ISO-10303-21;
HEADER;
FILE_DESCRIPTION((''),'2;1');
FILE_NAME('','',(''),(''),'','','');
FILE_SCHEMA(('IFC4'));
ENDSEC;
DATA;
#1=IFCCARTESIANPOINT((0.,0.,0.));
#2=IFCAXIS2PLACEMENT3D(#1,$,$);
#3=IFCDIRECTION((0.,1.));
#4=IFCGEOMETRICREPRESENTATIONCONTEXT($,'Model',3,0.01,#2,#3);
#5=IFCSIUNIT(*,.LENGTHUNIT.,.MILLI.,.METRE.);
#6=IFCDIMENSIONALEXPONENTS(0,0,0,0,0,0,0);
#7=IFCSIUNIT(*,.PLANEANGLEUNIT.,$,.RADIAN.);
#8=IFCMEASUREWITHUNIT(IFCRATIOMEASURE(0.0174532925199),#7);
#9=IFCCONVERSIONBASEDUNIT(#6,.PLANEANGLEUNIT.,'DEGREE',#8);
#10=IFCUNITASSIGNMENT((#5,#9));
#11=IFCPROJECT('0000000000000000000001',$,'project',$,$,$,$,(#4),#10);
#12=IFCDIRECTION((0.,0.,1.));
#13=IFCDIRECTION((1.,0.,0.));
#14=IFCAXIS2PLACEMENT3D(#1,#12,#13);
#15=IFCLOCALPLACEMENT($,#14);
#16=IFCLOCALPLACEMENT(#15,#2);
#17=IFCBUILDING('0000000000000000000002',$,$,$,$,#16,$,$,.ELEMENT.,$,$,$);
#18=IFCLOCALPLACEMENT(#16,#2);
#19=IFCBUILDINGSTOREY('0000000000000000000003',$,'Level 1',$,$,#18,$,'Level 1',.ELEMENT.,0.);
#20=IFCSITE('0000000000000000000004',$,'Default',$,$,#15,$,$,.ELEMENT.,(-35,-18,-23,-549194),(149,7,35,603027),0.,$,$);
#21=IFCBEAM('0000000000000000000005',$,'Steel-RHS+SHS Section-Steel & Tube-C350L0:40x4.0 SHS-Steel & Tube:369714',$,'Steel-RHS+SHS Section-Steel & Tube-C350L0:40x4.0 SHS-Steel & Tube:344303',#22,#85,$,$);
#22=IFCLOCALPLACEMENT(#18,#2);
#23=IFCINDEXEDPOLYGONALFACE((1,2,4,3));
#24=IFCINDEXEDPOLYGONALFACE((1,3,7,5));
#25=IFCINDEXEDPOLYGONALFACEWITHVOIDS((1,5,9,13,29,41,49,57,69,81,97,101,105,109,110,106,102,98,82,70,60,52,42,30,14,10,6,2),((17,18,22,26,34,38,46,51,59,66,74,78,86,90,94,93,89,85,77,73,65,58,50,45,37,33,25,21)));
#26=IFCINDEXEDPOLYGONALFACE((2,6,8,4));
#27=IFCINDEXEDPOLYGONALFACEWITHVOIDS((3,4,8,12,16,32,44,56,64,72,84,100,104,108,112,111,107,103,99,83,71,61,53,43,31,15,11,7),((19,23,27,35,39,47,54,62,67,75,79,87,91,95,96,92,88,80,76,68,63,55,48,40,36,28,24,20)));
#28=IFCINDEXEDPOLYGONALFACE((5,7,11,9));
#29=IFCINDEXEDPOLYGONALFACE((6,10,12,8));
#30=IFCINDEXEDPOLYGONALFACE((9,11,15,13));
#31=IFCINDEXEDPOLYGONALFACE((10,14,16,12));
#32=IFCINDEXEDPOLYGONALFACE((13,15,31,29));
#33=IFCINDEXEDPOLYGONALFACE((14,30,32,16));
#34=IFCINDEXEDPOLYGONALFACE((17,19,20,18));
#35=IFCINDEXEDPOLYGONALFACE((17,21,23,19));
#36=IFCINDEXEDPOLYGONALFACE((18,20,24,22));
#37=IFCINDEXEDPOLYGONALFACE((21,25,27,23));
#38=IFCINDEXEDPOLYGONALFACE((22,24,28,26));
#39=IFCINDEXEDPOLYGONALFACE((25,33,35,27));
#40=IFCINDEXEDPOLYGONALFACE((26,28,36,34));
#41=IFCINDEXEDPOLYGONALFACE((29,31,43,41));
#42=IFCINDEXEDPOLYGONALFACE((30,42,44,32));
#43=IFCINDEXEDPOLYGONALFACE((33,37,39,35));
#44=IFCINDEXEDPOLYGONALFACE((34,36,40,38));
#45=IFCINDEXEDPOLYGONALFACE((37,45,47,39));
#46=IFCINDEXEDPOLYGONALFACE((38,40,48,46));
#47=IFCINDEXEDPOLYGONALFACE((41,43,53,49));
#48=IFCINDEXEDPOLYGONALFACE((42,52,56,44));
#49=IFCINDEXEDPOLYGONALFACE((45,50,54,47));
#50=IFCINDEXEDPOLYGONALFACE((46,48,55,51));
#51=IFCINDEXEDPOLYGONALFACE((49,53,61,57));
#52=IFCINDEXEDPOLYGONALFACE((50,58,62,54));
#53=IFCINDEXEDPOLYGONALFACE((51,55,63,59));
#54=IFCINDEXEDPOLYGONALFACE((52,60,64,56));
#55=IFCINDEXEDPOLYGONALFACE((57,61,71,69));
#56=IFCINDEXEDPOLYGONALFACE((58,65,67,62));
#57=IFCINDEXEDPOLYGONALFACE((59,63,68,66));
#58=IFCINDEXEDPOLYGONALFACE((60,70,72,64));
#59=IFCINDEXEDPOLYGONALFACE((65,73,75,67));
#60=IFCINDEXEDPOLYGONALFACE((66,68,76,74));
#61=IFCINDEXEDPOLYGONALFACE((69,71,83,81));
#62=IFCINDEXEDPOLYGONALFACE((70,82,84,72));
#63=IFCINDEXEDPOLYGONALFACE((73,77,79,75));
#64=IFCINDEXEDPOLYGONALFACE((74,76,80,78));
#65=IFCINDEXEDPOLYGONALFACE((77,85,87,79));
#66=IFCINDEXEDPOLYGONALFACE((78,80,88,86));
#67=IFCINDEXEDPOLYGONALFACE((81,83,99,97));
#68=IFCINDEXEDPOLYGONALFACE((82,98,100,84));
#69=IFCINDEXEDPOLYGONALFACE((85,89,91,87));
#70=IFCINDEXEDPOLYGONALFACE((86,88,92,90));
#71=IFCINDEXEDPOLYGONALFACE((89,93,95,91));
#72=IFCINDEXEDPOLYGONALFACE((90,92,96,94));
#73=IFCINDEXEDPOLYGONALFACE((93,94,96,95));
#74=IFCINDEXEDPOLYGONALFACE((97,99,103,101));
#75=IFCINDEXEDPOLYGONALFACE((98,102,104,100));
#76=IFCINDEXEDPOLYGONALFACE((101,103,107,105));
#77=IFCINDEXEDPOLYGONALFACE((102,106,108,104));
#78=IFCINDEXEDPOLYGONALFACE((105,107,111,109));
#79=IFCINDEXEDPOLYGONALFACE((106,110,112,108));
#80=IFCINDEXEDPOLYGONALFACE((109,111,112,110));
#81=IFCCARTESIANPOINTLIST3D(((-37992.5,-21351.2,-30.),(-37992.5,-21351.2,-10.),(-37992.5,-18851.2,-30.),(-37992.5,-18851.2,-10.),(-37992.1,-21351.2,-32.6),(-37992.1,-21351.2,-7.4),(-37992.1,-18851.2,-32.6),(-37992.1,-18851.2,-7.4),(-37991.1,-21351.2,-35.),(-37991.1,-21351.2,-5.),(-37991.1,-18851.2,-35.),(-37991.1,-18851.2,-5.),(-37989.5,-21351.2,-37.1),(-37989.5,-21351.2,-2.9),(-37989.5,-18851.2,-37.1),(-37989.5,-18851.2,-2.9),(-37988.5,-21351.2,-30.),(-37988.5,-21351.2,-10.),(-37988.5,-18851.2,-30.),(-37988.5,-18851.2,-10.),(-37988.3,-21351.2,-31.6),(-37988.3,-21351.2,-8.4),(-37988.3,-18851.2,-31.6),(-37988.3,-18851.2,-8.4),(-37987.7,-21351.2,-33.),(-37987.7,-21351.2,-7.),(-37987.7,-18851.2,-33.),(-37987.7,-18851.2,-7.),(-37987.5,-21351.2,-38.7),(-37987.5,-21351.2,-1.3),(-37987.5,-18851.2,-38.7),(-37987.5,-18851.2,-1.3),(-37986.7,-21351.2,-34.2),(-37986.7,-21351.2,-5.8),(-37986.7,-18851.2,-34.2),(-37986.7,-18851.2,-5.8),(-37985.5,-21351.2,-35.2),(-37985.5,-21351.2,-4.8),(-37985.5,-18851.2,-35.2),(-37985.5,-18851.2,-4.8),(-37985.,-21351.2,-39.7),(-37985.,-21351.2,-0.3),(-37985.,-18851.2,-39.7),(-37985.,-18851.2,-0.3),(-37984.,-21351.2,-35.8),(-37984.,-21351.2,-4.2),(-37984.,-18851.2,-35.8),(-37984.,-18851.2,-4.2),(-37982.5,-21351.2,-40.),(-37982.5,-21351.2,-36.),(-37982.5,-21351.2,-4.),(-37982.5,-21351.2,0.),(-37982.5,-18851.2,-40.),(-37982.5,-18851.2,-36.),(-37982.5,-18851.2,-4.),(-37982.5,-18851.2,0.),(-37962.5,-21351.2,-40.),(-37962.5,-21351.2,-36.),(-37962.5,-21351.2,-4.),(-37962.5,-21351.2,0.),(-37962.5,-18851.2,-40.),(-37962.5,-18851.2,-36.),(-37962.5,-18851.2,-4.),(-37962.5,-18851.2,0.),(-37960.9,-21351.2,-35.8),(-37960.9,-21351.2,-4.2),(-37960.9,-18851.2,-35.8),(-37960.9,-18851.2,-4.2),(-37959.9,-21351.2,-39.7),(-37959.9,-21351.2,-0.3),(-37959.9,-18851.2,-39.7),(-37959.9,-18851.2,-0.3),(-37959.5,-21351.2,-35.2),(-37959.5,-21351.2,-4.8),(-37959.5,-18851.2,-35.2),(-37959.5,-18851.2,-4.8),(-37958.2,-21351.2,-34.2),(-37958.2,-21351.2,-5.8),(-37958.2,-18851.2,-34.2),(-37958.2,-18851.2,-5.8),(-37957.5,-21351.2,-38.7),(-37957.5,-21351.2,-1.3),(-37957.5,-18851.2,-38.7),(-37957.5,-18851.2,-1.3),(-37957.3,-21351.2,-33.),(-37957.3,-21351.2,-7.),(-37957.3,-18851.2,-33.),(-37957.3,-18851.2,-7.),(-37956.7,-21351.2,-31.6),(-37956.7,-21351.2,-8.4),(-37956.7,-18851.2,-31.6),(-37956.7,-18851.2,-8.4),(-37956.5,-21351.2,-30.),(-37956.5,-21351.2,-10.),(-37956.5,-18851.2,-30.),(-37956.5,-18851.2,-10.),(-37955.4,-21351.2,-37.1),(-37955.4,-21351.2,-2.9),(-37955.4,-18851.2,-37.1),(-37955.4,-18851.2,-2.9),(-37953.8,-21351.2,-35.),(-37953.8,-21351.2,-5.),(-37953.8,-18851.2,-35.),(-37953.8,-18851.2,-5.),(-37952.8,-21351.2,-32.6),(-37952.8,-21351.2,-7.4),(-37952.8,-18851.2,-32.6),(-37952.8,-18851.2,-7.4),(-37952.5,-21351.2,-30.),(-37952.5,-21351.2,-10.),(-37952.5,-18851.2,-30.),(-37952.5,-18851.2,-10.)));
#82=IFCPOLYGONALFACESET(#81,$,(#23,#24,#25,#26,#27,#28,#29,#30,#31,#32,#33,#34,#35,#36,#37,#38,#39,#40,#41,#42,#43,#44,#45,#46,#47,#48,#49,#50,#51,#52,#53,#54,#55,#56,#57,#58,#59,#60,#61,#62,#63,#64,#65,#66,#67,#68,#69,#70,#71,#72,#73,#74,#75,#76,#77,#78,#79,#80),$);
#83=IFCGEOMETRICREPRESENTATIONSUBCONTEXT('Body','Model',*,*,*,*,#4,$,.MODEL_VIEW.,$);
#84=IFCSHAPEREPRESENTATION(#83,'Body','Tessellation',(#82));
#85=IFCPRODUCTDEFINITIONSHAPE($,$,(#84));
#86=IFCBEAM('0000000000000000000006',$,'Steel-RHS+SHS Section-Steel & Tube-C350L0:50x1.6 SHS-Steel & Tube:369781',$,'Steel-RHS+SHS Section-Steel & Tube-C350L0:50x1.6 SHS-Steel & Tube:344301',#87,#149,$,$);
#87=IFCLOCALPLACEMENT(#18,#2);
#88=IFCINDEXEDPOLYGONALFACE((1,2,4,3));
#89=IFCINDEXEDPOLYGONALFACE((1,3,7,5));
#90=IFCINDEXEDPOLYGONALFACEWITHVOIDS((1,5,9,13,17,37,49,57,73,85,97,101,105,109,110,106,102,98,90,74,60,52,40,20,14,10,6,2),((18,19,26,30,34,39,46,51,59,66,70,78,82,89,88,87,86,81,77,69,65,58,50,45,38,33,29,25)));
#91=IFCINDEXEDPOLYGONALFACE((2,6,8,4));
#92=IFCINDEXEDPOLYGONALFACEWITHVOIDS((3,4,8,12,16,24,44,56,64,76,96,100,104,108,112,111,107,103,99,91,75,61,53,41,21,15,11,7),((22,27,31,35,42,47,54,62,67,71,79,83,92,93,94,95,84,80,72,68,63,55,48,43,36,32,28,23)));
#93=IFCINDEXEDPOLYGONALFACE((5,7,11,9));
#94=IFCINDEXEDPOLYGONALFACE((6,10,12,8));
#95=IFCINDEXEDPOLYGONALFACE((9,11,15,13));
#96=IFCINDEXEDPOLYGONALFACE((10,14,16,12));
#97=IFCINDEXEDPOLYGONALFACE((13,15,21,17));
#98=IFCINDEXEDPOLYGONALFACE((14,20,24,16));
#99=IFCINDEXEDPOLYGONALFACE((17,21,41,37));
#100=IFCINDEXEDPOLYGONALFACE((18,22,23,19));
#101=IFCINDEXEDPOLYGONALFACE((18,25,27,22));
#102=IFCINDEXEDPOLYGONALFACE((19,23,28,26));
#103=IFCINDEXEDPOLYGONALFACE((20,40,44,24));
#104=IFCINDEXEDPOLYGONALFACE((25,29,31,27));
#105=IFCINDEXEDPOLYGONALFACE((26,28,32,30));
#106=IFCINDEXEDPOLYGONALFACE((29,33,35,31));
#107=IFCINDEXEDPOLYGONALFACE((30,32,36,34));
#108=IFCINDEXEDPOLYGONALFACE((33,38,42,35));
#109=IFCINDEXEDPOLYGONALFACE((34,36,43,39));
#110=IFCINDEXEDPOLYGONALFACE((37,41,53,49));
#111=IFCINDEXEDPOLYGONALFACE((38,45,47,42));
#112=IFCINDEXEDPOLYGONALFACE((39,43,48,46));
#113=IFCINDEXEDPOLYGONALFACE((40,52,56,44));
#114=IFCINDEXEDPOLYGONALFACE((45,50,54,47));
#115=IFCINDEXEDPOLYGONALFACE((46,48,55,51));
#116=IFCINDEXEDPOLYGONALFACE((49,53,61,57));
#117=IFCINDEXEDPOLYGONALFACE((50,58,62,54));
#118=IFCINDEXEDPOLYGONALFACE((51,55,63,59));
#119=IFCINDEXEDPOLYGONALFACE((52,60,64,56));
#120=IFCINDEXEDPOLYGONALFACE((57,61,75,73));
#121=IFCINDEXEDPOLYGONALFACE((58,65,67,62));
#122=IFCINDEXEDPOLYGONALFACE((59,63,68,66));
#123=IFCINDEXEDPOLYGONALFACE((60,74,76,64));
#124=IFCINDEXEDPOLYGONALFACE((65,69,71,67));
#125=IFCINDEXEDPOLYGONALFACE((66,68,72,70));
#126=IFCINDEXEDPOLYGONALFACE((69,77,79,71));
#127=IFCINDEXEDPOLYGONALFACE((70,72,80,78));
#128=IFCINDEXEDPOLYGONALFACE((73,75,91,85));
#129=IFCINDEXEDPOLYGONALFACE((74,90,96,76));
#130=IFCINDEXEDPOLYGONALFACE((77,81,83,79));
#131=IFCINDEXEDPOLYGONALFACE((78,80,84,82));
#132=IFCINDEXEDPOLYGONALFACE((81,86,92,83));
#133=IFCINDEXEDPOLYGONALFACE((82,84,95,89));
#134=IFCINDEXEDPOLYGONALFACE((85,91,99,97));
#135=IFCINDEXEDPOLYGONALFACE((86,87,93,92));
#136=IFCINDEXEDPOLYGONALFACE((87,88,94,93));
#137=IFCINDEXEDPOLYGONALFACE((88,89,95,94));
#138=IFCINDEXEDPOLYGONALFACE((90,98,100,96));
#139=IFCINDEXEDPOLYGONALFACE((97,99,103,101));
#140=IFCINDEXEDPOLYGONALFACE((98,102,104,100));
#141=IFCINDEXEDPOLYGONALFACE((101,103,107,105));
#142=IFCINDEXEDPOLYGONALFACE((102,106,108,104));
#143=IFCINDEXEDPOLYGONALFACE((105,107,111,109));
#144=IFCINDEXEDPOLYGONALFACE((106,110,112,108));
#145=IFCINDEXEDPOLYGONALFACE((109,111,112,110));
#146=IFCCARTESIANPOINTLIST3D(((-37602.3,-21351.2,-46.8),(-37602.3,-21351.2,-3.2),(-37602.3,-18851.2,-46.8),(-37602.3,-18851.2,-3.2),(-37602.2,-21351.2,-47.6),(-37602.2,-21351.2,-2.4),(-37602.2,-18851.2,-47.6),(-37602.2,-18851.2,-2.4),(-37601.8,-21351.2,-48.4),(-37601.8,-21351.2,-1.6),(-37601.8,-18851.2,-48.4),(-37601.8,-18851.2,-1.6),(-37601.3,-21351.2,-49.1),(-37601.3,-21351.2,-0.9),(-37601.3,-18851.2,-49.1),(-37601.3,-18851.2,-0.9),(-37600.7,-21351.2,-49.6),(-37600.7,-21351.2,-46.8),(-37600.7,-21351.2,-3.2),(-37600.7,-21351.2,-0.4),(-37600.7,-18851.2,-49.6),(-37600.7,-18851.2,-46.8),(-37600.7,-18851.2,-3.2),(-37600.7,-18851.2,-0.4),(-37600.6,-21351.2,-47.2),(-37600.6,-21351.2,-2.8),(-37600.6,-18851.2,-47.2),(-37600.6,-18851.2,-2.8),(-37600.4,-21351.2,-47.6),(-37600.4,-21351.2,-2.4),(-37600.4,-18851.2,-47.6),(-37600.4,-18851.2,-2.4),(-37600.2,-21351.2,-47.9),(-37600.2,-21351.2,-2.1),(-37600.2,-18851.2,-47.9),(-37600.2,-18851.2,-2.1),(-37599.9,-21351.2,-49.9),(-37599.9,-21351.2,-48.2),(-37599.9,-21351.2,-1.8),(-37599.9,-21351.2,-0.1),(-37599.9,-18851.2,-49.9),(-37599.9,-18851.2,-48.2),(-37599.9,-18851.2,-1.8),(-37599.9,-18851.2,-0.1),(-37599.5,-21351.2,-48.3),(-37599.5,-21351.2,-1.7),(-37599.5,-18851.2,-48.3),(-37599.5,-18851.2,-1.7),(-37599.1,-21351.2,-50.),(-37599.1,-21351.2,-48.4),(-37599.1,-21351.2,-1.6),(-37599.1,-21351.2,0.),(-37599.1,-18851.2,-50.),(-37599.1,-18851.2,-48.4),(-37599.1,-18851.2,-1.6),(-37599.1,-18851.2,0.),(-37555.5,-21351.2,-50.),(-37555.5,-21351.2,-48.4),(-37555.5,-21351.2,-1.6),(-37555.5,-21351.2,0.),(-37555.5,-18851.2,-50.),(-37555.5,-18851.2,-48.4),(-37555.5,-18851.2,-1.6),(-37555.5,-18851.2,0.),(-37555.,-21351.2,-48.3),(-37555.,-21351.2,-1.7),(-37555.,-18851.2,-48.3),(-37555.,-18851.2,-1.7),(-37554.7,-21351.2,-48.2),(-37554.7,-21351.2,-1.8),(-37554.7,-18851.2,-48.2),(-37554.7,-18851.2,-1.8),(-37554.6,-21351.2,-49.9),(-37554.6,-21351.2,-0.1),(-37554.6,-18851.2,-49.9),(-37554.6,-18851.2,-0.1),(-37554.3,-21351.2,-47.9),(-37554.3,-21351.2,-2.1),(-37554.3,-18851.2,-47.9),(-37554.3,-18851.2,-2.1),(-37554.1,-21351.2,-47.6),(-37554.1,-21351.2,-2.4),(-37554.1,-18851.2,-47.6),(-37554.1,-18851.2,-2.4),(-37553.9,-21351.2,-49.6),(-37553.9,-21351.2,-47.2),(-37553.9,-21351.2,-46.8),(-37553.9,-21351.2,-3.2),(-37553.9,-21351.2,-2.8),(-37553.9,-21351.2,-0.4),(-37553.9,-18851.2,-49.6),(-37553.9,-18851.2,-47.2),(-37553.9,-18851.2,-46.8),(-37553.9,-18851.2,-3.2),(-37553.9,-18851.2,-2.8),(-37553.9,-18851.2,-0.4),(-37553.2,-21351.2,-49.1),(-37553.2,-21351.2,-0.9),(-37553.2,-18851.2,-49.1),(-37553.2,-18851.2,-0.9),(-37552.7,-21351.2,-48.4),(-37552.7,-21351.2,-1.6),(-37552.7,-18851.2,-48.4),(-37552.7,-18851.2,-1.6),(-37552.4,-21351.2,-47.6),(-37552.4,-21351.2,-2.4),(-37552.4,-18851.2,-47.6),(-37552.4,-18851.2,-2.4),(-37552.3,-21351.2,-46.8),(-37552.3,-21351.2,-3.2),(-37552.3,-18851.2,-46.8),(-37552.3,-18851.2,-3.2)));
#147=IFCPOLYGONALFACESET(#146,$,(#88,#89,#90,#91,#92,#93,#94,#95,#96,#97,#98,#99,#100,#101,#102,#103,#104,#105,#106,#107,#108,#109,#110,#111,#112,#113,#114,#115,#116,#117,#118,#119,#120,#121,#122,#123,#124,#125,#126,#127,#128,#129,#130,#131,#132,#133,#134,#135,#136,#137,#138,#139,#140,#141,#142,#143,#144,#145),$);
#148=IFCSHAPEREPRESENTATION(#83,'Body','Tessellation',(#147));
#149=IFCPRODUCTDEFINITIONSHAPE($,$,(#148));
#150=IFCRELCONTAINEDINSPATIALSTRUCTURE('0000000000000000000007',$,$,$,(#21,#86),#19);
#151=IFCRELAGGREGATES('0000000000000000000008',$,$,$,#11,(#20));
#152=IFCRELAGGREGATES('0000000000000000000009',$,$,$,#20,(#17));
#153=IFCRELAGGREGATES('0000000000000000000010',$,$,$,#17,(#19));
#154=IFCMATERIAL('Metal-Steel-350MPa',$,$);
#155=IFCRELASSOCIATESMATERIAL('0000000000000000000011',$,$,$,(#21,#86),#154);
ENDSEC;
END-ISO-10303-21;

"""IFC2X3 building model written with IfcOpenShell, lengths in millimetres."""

from ifc_helpers import new_model, entity, si_unit, converted_unit, direction, frame, frame_2d, origin, origin_with_axes, place, context, subcontext, project, spatial, polyline, circle_curve, parameter, trimmed, segment, composite_curve, outline, extrude, material, element, save


model = new_model("IFC2X3")

# Units and contexts
model_context = context("Model", 3, precision=0.01, world=origin(), true_north=direction((0.0, 1.0)))
body_context = subcontext(model_context, "Body", "Model", "MODEL_VIEW")
ifc_project = project(units=[si_unit("LENGTHUNIT", "METRE", prefix="MILLI"), converted_unit("PLANEANGLEUNIT", "DEGREE", entity("IfcRatioMeasure", 0.0174532925199), si_unit("PLANEANGLEUNIT", "RADIAN"), dimensions=[0, 0, 0, 0, 0, 0, 0])], contexts=[model_context])

# Site, building, storey
site_placement = place(None, origin_with_axes())
site = spatial("IfcSite", under=ifc_project, at=site_placement, Name="Default", CompositionType="ELEMENT", RefLatitude=(-35, -18, -23, -549194), RefLongitude=(149, 7, 35, 603027), RefElevation=0.0)
building_placement = place(site_placement, origin())
building = spatial("IfcBuilding", under=site, at=building_placement, CompositionType="ELEMENT")
storey_placement = place(building_placement, origin())
storey = spatial("IfcBuildingStorey", under=building, at=storey_placement, Name="Level 1", LongName="Level 1", CompositionType="ELEMENT", Elevation=0.0)

# Beams
ifc_material = material(Name="Metal-Steel-350MPa")
beam_1_placement = place(storey_placement, frame((-37972.5, -18851.2, 0.0), z_axis=(0.0, 0.0, 1.0), x_axis=(0.0, -1.0, 0.0)))
element("IfcBeam", 1, at=beam_1_placement, inside=storey, material=ifc_material, Name="Steel-RHS+SHS Section-Steel & Tube-C350L0:40x4.0 SHS-Steel & Tube:369714", ObjectType="Steel-RHS+SHS Section-Steel & Tube-C350L0:40x4.0 SHS-Steel & Tube:344303", context=body_context, shape_type="SweptSolid", body=[
    extrude(outline(composite_curve([segment(trimmed(circle_curve(frame_2d((-10.0, -10.0), x_axis=(1.0, 0.0)), 10.0), [parameter(180.0)], [parameter(270.0)], True, "PARAMETER"), True, "CONTINUOUS"), segment(polyline([(-10.0, -20.0), (10.0, -20.0)]), True, "CONTINUOUS"), segment(trimmed(circle_curve(frame_2d((10.0, -10.0), x_axis=(1.0, 0.0)), 10.0), [parameter(270.0)], [parameter(0.0)], True, "PARAMETER"), True, "CONTINUOUS"), segment(polyline([(20.0, -10.0), (20.0, 10.0)]), True, "CONTINUOUS"), segment(trimmed(circle_curve(frame_2d((10.0, 10.0), x_axis=(1.0, 0.0)), 10.0), [parameter(0.0)], [parameter(90.0)], True, "PARAMETER"), True, "CONTINUOUS"), segment(polyline([(10.0, 20.0), (-10.0, 20.0)]), True, "CONTINUOUS"), segment(trimmed(circle_curve(frame_2d((-10.0, 10.0), x_axis=(1.0, 0.0)), 10.0), [parameter(90.0)], [parameter(180.0)], True, "PARAMETER"), True, "CONTINUOUS"), segment(polyline([(-20.0, 10.0), (-20.0, -10.0)]), True, "CONTINUOUS")], self_intersect=False), holes=[composite_curve([segment(polyline([(10.0, -16.0), (-10.0, -16.0)]), True, "CONTINUOUS"), segment(trimmed(circle_curve(frame_2d((-10.0, -10.0), x_axis=(1.0, 0.0)), 6.0), [parameter(180.0)], [parameter(270.0)], True, "PARAMETER"), False, "CONTINUOUS"), segment(polyline([(-16.0, -10.0), (-16.0, 10.0)]), True, "CONTINUOUS"), segment(trimmed(circle_curve(frame_2d((-10.0, 10.0), x_axis=(1.0, 0.0)), 6.0), [parameter(90.0)], [parameter(180.0)], True, "PARAMETER"), False, "CONTINUOUS"), segment(polyline([(-10.0, 16.0), (10.0, 16.0)]), True, "CONTINUOUS"), segment(trimmed(circle_curve(frame_2d((10.0, 10.0), x_axis=(1.0, 0.0)), 6.0), [parameter(360.0)], [parameter(90.0)], True, "PARAMETER"), False, "CONTINUOUS"), segment(polyline([(16.0, 10.0), (16.0, -10.0)]), True, "CONTINUOUS"), segment(trimmed(circle_curve(frame_2d((10.0, -10.0), x_axis=(1.0, 0.0)), 6.0), [parameter(270.0)], [parameter(0.0)], True, "PARAMETER"), False, "CONTINUOUS")], self_intersect=False)]), frame((0.0, 0.0, -20.0), z_axis=(1.0, 0.0, 0.0), x_axis=(0.0, -1.0, 0.0)), (0.0, 0.0, 1.0), 2500.0),
])
beam_2_placement = place(storey_placement, frame((-37577.3, -18851.2, 0.0), z_axis=(0.0, 0.0, 1.0), x_axis=(0.0, -1.0, 0.0)))
element("IfcBeam", 2, at=beam_2_placement, inside=storey, material=ifc_material, Name="Steel-RHS+SHS Section-Steel & Tube-C350L0:50x1.6 SHS-Steel & Tube:369781", ObjectType="Steel-RHS+SHS Section-Steel & Tube-C350L0:50x1.6 SHS-Steel & Tube:344301", context=body_context, shape_type="SweptSolid", body=[
    extrude(outline(composite_curve([segment(trimmed(circle_curve(frame_2d((-21.8, -21.8), x_axis=(1.0, 0.0)), 3.2), [parameter(180.0)], [parameter(270.0)], True, "PARAMETER"), True, "CONTINUOUS"), segment(polyline([(-21.8, -25.0), (21.8, -25.0)]), True, "CONTINUOUS"), segment(trimmed(circle_curve(frame_2d((21.8, -21.8), x_axis=(1.0, 0.0)), 3.2), [parameter(270.0)], [parameter(0.0)], True, "PARAMETER"), True, "CONTINUOUS"), segment(polyline([(25.0, -21.8), (25.0, 21.8)]), True, "CONTINUOUS"), segment(trimmed(circle_curve(frame_2d((21.8, 21.8), x_axis=(1.0, 0.0)), 3.2), [parameter(0.0)], [parameter(90.0)], True, "PARAMETER"), True, "CONTINUOUS"), segment(polyline([(21.8, 25.0), (-21.8, 25.0)]), True, "CONTINUOUS"), segment(trimmed(circle_curve(frame_2d((-21.8, 21.8), x_axis=(1.0, 0.0)), 3.2), [parameter(90.0)], [parameter(180.0)], True, "PARAMETER"), True, "CONTINUOUS"), segment(polyline([(-25.0, 21.8), (-25.0, -21.8)]), True, "CONTINUOUS")], self_intersect=False), holes=[composite_curve([segment(polyline([(21.8, -23.4), (-21.8, -23.4)]), True, "CONTINUOUS"), segment(trimmed(circle_curve(frame_2d((-21.8, -21.8), x_axis=(1.0, 0.0)), 1.6), [parameter(180.0)], [parameter(270.0)], True, "PARAMETER"), False, "CONTINUOUS"), segment(polyline([(-23.4, -21.8), (-23.4, 21.8)]), True, "CONTINUOUS"), segment(trimmed(circle_curve(frame_2d((-21.8, 21.8), x_axis=(1.0, 0.0)), 1.6), [parameter(90.0)], [parameter(180.0)], True, "PARAMETER"), False, "CONTINUOUS"), segment(polyline([(-21.8, 23.4), (21.8, 23.4)]), True, "CONTINUOUS"), segment(trimmed(circle_curve(frame_2d((21.8, 21.8), x_axis=(1.0, 0.0)), 1.6), [parameter(360.0)], [parameter(90.0)], True, "PARAMETER"), False, "CONTINUOUS"), segment(polyline([(23.4, 21.8), (23.4, -21.8)]), True, "CONTINUOUS"), segment(trimmed(circle_curve(frame_2d((21.8, -21.8), x_axis=(1.0, 0.0)), 1.6), [parameter(270.0)], [parameter(360.0)], True, "PARAMETER"), False, "CONTINUOUS")], self_intersect=False)]), frame((0.0, 0.0, -25.0), z_axis=(1.0, 0.0, 0.0), x_axis=(0.0, -1.0, 0.0)), (0.0, 0.0, 1.0), 2500.0),
])

save(model, "model.ifc")
